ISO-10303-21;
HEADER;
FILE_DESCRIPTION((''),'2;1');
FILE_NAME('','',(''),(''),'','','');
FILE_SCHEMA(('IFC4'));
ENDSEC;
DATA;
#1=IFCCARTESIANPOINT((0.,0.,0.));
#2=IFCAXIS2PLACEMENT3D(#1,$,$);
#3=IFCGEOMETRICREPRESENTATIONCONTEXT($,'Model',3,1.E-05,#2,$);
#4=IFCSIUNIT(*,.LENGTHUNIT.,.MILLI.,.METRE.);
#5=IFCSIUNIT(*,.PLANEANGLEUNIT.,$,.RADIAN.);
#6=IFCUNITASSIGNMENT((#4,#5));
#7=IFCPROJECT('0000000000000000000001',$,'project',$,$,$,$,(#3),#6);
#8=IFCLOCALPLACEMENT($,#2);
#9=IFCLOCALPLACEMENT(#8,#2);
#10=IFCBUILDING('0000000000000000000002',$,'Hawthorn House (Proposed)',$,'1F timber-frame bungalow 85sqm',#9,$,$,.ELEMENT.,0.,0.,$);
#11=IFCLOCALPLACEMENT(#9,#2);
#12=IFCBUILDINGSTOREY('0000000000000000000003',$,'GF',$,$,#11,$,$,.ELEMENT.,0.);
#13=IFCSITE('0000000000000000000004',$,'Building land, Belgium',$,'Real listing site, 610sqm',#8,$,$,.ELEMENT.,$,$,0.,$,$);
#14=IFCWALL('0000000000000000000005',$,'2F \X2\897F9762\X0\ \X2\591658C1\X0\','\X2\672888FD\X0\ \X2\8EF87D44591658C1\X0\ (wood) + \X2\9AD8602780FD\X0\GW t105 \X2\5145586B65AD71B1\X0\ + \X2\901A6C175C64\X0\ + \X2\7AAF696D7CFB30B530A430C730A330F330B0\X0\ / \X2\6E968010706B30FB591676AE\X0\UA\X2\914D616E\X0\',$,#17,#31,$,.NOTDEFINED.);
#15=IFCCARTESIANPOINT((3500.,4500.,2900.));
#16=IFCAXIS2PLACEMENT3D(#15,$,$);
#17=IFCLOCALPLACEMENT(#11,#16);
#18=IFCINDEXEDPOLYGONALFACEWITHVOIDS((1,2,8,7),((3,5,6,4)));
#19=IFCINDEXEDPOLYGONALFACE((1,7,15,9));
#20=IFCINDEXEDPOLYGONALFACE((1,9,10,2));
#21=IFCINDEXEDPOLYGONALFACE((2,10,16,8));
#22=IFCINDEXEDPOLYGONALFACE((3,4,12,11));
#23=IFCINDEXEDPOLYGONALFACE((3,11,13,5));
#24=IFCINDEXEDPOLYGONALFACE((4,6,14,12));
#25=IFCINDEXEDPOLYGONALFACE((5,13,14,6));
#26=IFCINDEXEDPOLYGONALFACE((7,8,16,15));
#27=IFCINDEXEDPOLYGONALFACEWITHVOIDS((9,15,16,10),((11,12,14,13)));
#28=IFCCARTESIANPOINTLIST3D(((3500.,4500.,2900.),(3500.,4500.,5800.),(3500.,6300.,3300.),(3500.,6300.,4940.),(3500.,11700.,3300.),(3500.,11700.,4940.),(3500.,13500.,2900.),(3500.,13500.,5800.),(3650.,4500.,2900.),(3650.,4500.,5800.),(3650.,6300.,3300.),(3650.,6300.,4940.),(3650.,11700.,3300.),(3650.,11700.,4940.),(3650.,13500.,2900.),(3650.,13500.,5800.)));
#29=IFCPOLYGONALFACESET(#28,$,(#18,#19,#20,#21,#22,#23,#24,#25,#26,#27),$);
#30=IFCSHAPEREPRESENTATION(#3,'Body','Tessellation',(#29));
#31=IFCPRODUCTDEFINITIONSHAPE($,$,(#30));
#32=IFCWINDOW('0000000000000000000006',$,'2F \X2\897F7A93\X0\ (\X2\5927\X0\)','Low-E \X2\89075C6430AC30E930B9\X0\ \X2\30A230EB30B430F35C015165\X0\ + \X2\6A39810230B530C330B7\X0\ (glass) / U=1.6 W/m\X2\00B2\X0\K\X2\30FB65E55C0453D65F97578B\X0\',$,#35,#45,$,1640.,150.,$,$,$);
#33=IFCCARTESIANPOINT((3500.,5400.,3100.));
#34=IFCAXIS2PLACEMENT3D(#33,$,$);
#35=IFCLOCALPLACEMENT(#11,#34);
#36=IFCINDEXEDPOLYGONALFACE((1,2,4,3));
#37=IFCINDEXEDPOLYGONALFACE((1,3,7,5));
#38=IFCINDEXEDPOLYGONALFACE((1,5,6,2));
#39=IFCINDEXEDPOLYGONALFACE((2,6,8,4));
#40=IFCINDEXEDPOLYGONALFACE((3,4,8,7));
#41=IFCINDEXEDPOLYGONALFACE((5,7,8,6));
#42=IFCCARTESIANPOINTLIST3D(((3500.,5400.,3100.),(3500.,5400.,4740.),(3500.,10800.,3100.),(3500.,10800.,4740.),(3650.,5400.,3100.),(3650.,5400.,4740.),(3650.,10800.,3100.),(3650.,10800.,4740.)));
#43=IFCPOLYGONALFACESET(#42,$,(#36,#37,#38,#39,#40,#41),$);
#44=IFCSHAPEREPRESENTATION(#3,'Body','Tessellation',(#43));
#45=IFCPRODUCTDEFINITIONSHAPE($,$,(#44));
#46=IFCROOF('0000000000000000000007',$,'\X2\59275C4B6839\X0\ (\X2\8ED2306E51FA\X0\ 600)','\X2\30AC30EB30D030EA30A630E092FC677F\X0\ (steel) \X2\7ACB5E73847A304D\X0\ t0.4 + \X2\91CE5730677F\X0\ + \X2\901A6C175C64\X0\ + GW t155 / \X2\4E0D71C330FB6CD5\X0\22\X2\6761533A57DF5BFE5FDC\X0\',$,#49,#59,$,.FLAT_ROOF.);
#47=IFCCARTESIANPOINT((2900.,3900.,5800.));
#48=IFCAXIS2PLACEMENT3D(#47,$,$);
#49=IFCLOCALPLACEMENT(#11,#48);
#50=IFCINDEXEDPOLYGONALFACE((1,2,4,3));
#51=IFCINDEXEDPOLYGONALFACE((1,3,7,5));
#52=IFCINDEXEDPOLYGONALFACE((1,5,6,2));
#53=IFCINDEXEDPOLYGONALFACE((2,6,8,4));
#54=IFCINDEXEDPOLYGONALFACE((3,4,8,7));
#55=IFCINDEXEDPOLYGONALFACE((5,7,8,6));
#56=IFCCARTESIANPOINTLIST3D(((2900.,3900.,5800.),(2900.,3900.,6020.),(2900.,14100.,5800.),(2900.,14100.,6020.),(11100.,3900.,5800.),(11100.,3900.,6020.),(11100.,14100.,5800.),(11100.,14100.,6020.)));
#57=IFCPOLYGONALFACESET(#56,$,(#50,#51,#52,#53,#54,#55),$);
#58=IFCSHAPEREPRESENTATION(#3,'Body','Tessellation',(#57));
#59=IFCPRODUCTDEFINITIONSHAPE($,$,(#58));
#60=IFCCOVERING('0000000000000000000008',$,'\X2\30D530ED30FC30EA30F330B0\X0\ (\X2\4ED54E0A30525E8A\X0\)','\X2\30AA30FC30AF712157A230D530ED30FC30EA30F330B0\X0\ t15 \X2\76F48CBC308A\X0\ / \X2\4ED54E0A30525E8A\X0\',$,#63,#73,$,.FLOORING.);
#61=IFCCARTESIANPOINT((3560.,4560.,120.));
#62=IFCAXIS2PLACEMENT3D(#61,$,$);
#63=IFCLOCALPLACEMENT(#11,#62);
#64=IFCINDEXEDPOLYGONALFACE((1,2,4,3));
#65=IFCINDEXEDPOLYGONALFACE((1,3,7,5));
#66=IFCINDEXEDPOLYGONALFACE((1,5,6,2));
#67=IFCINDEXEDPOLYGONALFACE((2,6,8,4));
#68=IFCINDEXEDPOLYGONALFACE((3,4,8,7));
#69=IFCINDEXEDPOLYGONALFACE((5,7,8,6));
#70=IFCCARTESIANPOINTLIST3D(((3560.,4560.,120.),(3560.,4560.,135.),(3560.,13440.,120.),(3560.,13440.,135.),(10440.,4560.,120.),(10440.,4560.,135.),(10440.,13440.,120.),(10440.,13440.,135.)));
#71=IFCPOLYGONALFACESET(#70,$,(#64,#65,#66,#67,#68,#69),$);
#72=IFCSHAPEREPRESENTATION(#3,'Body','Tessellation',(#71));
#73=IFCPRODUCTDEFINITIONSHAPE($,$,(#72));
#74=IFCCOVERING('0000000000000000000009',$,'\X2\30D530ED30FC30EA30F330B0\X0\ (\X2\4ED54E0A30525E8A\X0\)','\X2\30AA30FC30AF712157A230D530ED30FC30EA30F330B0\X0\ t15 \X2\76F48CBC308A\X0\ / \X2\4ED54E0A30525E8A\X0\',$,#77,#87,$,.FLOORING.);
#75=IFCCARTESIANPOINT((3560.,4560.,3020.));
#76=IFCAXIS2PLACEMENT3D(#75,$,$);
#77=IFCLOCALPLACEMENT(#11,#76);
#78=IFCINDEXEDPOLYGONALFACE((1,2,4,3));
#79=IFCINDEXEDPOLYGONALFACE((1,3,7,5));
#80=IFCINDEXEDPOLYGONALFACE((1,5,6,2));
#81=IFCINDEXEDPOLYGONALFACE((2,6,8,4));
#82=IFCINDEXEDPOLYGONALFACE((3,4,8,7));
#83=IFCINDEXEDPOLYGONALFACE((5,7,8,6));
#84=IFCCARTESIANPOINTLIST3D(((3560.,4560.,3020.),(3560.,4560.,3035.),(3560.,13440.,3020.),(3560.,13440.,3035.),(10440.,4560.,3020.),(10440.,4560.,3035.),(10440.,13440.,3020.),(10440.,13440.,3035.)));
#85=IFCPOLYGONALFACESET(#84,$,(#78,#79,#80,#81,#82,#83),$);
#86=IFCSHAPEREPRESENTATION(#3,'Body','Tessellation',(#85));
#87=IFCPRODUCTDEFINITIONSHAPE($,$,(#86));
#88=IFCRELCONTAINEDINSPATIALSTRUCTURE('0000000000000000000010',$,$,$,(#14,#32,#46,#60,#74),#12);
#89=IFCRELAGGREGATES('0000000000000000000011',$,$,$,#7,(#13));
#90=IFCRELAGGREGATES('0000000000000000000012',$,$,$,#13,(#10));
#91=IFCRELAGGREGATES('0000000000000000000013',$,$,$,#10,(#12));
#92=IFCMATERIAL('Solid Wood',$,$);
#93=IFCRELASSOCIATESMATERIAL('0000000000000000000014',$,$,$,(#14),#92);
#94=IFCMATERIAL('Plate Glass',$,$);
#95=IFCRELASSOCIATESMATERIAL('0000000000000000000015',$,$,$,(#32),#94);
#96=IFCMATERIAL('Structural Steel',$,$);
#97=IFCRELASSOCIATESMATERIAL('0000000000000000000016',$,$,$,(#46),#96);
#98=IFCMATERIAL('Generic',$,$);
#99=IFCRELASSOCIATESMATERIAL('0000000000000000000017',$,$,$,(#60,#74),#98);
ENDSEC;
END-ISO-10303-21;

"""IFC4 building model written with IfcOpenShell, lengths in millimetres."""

from ifc_helpers import new_model, si_unit, frame, frame_2d, origin, place, context, project, spatial, rectangle, extrude, material, element, fill, save


model = new_model("IFC4")

# Units and contexts
model_context = context("Model", 3, precision=1e-05, world=origin())
ifc_project = project(units=[si_unit("LENGTHUNIT", "METRE", prefix="MILLI"), si_unit("PLANEANGLEUNIT", "RADIAN")], contexts=[model_context])

# Site, building, storey
site_placement = place(None, origin())
site = spatial("IfcSite", under=ifc_project, at=site_placement, Name="Building land, Belgium", ObjectType="Real listing site, 610sqm", CompositionType="ELEMENT", RefElevation=0.0)
building_placement = place(site_placement, origin())
building = spatial("IfcBuilding", under=site, at=building_placement, Name="Hawthorn House (Proposed)", ObjectType="1F timber-frame bungalow 85sqm", CompositionType="ELEMENT", ElevationOfRefHeight=0.0, ElevationOfTerrain=0.0)
storey_placement = place(building_placement, origin())
storey = spatial("IfcBuildingStorey", under=building, at=storey_placement, Name="GF", CompositionType="ELEMENT", Elevation=0.0)

# Shared definitions
ifc_material_1 = material(Name="Solid Wood")
ifc_material_2 = material(Name="Generic")

# Shared definitions
ifc_material_3 = material(Name="Plate Glass")

# Wall, opening, window
wall_1_placement = place(storey_placement, frame((3500.0, 4500.0, 2900.0)))
wall_1 = element("IfcWall", 1, at=wall_1_placement, inside=storey, material=ifc_material_1, Name="2F 西面 外壁", Description="木製 軸組外壁 (wood) + 高性能GW t105 充填断熱 + 通気層 + 窯業系サイディング / 準耐火・外皮UA配慮", PredefinedType="NOTDEFINED", context=model_context, shape_type="SweptSolid", body=[
    extrude(rectangle(XDim=150.0, YDim=9000.0, at=frame_2d((75.0, 4500.0))), frame((3500.0, 4500.0, 2900.0)), (0.0, 0.0, 1.0), 2900.0),
])
opening_1_placement = place(storey_placement, frame((3500.0, 5400.0, 3100.0)))
opening_1 = element("IfcOpeningElement", 2, at=opening_1_placement, cuts=wall_1, PredefinedType="NOTDEFINED", context=model_context, shape_type="SweptSolid", body=[
    extrude(rectangle(XDim=150.0, YDim=5400.0, at=frame_2d((75.0, 2700.0))), frame((3500.0, 5400.0, 3100.0)), (0.0, 0.0, 1.0), 1640.0),
])
window_1_placement = place(storey_placement, frame((3500.0, 5400.0, 3100.0)))
window_1 = element("IfcWindow", 3, at=window_1_placement, inside=storey, material=ifc_material_3, Name="2F 西窓 (大)", Description="Low-E 複層ガラス アルゴン封入 + 樹脂サッシ (glass) / U=1.6 W/m²K・日射取得型", OverallHeight=1640.0, OverallWidth=150.0, context=model_context, shape_type="SweptSolid", body=[
    extrude(rectangle(XDim=150.0, YDim=5400.0, at=frame_2d((75.0, 2700.0))), frame((3500.0, 5400.0, 3100.0)), (0.0, 0.0, 1.0), 1640.0),
])
fill(opening_1, window_1)

# Roof
ifc_material_4 = material(Name="Structural Steel")
roof_placement = place(storey_placement, frame((2900.0, 3900.0, 5800.0)))
element("IfcRoof", 4, at=roof_placement, inside=storey, material=ifc_material_4, Name="大屋根 (軒の出 600)", Description="ガルバリウム鋼板 (steel) 立平葺き t0.4 + 野地板 + 通気層 + GW t155 / 不燃・法22条区域対応", PredefinedType="FLAT_ROOF", context=model_context, shape_type="SweptSolid", body=[
    extrude(rectangle(XDim=8200.0, YDim=10200.0, at=frame_2d((4100.0, 5100.0))), frame((2900.0, 3900.0, 5800.0)), (0.0, 0.0, 1.0), 220.0),
])

# Coverings
covering_1_placement = place(storey_placement, frame((3560.0, 4560.0, 120.0)))
element("IfcCovering", 5, at=covering_1_placement, inside=storey, material=ifc_material_2, Name="フローリング (仕上げ床)", Description="オーク無垢フローリング t15 直貼り / 仕上げ床", PredefinedType="FLOORING", context=model_context, shape_type="SweptSolid", body=[
    extrude(rectangle(XDim=6880.0, YDim=8880.0, at=frame_2d((3440.0, 4440.0))), frame((3560.0, 4560.0, 120.0)), (0.0, 0.0, 1.0), 15.0),
])
covering_2_placement = place(storey_placement, frame((3560.0, 4560.0, 3020.0)))
element("IfcCovering", 6, at=covering_2_placement, inside=storey, material=ifc_material_2, Name="フローリング (仕上げ床)", Description="オーク無垢フローリング t15 直貼り / 仕上げ床", PredefinedType="FLOORING", context=model_context, shape_type="SweptSolid", body=[
    extrude(rectangle(XDim=6880.0, YDim=8880.0, at=frame_2d((3440.0, 4440.0))), frame((3560.0, 4560.0, 3020.0)), (0.0, 0.0, 1.0), 15.0),
])

save(model, "model.ifc")
